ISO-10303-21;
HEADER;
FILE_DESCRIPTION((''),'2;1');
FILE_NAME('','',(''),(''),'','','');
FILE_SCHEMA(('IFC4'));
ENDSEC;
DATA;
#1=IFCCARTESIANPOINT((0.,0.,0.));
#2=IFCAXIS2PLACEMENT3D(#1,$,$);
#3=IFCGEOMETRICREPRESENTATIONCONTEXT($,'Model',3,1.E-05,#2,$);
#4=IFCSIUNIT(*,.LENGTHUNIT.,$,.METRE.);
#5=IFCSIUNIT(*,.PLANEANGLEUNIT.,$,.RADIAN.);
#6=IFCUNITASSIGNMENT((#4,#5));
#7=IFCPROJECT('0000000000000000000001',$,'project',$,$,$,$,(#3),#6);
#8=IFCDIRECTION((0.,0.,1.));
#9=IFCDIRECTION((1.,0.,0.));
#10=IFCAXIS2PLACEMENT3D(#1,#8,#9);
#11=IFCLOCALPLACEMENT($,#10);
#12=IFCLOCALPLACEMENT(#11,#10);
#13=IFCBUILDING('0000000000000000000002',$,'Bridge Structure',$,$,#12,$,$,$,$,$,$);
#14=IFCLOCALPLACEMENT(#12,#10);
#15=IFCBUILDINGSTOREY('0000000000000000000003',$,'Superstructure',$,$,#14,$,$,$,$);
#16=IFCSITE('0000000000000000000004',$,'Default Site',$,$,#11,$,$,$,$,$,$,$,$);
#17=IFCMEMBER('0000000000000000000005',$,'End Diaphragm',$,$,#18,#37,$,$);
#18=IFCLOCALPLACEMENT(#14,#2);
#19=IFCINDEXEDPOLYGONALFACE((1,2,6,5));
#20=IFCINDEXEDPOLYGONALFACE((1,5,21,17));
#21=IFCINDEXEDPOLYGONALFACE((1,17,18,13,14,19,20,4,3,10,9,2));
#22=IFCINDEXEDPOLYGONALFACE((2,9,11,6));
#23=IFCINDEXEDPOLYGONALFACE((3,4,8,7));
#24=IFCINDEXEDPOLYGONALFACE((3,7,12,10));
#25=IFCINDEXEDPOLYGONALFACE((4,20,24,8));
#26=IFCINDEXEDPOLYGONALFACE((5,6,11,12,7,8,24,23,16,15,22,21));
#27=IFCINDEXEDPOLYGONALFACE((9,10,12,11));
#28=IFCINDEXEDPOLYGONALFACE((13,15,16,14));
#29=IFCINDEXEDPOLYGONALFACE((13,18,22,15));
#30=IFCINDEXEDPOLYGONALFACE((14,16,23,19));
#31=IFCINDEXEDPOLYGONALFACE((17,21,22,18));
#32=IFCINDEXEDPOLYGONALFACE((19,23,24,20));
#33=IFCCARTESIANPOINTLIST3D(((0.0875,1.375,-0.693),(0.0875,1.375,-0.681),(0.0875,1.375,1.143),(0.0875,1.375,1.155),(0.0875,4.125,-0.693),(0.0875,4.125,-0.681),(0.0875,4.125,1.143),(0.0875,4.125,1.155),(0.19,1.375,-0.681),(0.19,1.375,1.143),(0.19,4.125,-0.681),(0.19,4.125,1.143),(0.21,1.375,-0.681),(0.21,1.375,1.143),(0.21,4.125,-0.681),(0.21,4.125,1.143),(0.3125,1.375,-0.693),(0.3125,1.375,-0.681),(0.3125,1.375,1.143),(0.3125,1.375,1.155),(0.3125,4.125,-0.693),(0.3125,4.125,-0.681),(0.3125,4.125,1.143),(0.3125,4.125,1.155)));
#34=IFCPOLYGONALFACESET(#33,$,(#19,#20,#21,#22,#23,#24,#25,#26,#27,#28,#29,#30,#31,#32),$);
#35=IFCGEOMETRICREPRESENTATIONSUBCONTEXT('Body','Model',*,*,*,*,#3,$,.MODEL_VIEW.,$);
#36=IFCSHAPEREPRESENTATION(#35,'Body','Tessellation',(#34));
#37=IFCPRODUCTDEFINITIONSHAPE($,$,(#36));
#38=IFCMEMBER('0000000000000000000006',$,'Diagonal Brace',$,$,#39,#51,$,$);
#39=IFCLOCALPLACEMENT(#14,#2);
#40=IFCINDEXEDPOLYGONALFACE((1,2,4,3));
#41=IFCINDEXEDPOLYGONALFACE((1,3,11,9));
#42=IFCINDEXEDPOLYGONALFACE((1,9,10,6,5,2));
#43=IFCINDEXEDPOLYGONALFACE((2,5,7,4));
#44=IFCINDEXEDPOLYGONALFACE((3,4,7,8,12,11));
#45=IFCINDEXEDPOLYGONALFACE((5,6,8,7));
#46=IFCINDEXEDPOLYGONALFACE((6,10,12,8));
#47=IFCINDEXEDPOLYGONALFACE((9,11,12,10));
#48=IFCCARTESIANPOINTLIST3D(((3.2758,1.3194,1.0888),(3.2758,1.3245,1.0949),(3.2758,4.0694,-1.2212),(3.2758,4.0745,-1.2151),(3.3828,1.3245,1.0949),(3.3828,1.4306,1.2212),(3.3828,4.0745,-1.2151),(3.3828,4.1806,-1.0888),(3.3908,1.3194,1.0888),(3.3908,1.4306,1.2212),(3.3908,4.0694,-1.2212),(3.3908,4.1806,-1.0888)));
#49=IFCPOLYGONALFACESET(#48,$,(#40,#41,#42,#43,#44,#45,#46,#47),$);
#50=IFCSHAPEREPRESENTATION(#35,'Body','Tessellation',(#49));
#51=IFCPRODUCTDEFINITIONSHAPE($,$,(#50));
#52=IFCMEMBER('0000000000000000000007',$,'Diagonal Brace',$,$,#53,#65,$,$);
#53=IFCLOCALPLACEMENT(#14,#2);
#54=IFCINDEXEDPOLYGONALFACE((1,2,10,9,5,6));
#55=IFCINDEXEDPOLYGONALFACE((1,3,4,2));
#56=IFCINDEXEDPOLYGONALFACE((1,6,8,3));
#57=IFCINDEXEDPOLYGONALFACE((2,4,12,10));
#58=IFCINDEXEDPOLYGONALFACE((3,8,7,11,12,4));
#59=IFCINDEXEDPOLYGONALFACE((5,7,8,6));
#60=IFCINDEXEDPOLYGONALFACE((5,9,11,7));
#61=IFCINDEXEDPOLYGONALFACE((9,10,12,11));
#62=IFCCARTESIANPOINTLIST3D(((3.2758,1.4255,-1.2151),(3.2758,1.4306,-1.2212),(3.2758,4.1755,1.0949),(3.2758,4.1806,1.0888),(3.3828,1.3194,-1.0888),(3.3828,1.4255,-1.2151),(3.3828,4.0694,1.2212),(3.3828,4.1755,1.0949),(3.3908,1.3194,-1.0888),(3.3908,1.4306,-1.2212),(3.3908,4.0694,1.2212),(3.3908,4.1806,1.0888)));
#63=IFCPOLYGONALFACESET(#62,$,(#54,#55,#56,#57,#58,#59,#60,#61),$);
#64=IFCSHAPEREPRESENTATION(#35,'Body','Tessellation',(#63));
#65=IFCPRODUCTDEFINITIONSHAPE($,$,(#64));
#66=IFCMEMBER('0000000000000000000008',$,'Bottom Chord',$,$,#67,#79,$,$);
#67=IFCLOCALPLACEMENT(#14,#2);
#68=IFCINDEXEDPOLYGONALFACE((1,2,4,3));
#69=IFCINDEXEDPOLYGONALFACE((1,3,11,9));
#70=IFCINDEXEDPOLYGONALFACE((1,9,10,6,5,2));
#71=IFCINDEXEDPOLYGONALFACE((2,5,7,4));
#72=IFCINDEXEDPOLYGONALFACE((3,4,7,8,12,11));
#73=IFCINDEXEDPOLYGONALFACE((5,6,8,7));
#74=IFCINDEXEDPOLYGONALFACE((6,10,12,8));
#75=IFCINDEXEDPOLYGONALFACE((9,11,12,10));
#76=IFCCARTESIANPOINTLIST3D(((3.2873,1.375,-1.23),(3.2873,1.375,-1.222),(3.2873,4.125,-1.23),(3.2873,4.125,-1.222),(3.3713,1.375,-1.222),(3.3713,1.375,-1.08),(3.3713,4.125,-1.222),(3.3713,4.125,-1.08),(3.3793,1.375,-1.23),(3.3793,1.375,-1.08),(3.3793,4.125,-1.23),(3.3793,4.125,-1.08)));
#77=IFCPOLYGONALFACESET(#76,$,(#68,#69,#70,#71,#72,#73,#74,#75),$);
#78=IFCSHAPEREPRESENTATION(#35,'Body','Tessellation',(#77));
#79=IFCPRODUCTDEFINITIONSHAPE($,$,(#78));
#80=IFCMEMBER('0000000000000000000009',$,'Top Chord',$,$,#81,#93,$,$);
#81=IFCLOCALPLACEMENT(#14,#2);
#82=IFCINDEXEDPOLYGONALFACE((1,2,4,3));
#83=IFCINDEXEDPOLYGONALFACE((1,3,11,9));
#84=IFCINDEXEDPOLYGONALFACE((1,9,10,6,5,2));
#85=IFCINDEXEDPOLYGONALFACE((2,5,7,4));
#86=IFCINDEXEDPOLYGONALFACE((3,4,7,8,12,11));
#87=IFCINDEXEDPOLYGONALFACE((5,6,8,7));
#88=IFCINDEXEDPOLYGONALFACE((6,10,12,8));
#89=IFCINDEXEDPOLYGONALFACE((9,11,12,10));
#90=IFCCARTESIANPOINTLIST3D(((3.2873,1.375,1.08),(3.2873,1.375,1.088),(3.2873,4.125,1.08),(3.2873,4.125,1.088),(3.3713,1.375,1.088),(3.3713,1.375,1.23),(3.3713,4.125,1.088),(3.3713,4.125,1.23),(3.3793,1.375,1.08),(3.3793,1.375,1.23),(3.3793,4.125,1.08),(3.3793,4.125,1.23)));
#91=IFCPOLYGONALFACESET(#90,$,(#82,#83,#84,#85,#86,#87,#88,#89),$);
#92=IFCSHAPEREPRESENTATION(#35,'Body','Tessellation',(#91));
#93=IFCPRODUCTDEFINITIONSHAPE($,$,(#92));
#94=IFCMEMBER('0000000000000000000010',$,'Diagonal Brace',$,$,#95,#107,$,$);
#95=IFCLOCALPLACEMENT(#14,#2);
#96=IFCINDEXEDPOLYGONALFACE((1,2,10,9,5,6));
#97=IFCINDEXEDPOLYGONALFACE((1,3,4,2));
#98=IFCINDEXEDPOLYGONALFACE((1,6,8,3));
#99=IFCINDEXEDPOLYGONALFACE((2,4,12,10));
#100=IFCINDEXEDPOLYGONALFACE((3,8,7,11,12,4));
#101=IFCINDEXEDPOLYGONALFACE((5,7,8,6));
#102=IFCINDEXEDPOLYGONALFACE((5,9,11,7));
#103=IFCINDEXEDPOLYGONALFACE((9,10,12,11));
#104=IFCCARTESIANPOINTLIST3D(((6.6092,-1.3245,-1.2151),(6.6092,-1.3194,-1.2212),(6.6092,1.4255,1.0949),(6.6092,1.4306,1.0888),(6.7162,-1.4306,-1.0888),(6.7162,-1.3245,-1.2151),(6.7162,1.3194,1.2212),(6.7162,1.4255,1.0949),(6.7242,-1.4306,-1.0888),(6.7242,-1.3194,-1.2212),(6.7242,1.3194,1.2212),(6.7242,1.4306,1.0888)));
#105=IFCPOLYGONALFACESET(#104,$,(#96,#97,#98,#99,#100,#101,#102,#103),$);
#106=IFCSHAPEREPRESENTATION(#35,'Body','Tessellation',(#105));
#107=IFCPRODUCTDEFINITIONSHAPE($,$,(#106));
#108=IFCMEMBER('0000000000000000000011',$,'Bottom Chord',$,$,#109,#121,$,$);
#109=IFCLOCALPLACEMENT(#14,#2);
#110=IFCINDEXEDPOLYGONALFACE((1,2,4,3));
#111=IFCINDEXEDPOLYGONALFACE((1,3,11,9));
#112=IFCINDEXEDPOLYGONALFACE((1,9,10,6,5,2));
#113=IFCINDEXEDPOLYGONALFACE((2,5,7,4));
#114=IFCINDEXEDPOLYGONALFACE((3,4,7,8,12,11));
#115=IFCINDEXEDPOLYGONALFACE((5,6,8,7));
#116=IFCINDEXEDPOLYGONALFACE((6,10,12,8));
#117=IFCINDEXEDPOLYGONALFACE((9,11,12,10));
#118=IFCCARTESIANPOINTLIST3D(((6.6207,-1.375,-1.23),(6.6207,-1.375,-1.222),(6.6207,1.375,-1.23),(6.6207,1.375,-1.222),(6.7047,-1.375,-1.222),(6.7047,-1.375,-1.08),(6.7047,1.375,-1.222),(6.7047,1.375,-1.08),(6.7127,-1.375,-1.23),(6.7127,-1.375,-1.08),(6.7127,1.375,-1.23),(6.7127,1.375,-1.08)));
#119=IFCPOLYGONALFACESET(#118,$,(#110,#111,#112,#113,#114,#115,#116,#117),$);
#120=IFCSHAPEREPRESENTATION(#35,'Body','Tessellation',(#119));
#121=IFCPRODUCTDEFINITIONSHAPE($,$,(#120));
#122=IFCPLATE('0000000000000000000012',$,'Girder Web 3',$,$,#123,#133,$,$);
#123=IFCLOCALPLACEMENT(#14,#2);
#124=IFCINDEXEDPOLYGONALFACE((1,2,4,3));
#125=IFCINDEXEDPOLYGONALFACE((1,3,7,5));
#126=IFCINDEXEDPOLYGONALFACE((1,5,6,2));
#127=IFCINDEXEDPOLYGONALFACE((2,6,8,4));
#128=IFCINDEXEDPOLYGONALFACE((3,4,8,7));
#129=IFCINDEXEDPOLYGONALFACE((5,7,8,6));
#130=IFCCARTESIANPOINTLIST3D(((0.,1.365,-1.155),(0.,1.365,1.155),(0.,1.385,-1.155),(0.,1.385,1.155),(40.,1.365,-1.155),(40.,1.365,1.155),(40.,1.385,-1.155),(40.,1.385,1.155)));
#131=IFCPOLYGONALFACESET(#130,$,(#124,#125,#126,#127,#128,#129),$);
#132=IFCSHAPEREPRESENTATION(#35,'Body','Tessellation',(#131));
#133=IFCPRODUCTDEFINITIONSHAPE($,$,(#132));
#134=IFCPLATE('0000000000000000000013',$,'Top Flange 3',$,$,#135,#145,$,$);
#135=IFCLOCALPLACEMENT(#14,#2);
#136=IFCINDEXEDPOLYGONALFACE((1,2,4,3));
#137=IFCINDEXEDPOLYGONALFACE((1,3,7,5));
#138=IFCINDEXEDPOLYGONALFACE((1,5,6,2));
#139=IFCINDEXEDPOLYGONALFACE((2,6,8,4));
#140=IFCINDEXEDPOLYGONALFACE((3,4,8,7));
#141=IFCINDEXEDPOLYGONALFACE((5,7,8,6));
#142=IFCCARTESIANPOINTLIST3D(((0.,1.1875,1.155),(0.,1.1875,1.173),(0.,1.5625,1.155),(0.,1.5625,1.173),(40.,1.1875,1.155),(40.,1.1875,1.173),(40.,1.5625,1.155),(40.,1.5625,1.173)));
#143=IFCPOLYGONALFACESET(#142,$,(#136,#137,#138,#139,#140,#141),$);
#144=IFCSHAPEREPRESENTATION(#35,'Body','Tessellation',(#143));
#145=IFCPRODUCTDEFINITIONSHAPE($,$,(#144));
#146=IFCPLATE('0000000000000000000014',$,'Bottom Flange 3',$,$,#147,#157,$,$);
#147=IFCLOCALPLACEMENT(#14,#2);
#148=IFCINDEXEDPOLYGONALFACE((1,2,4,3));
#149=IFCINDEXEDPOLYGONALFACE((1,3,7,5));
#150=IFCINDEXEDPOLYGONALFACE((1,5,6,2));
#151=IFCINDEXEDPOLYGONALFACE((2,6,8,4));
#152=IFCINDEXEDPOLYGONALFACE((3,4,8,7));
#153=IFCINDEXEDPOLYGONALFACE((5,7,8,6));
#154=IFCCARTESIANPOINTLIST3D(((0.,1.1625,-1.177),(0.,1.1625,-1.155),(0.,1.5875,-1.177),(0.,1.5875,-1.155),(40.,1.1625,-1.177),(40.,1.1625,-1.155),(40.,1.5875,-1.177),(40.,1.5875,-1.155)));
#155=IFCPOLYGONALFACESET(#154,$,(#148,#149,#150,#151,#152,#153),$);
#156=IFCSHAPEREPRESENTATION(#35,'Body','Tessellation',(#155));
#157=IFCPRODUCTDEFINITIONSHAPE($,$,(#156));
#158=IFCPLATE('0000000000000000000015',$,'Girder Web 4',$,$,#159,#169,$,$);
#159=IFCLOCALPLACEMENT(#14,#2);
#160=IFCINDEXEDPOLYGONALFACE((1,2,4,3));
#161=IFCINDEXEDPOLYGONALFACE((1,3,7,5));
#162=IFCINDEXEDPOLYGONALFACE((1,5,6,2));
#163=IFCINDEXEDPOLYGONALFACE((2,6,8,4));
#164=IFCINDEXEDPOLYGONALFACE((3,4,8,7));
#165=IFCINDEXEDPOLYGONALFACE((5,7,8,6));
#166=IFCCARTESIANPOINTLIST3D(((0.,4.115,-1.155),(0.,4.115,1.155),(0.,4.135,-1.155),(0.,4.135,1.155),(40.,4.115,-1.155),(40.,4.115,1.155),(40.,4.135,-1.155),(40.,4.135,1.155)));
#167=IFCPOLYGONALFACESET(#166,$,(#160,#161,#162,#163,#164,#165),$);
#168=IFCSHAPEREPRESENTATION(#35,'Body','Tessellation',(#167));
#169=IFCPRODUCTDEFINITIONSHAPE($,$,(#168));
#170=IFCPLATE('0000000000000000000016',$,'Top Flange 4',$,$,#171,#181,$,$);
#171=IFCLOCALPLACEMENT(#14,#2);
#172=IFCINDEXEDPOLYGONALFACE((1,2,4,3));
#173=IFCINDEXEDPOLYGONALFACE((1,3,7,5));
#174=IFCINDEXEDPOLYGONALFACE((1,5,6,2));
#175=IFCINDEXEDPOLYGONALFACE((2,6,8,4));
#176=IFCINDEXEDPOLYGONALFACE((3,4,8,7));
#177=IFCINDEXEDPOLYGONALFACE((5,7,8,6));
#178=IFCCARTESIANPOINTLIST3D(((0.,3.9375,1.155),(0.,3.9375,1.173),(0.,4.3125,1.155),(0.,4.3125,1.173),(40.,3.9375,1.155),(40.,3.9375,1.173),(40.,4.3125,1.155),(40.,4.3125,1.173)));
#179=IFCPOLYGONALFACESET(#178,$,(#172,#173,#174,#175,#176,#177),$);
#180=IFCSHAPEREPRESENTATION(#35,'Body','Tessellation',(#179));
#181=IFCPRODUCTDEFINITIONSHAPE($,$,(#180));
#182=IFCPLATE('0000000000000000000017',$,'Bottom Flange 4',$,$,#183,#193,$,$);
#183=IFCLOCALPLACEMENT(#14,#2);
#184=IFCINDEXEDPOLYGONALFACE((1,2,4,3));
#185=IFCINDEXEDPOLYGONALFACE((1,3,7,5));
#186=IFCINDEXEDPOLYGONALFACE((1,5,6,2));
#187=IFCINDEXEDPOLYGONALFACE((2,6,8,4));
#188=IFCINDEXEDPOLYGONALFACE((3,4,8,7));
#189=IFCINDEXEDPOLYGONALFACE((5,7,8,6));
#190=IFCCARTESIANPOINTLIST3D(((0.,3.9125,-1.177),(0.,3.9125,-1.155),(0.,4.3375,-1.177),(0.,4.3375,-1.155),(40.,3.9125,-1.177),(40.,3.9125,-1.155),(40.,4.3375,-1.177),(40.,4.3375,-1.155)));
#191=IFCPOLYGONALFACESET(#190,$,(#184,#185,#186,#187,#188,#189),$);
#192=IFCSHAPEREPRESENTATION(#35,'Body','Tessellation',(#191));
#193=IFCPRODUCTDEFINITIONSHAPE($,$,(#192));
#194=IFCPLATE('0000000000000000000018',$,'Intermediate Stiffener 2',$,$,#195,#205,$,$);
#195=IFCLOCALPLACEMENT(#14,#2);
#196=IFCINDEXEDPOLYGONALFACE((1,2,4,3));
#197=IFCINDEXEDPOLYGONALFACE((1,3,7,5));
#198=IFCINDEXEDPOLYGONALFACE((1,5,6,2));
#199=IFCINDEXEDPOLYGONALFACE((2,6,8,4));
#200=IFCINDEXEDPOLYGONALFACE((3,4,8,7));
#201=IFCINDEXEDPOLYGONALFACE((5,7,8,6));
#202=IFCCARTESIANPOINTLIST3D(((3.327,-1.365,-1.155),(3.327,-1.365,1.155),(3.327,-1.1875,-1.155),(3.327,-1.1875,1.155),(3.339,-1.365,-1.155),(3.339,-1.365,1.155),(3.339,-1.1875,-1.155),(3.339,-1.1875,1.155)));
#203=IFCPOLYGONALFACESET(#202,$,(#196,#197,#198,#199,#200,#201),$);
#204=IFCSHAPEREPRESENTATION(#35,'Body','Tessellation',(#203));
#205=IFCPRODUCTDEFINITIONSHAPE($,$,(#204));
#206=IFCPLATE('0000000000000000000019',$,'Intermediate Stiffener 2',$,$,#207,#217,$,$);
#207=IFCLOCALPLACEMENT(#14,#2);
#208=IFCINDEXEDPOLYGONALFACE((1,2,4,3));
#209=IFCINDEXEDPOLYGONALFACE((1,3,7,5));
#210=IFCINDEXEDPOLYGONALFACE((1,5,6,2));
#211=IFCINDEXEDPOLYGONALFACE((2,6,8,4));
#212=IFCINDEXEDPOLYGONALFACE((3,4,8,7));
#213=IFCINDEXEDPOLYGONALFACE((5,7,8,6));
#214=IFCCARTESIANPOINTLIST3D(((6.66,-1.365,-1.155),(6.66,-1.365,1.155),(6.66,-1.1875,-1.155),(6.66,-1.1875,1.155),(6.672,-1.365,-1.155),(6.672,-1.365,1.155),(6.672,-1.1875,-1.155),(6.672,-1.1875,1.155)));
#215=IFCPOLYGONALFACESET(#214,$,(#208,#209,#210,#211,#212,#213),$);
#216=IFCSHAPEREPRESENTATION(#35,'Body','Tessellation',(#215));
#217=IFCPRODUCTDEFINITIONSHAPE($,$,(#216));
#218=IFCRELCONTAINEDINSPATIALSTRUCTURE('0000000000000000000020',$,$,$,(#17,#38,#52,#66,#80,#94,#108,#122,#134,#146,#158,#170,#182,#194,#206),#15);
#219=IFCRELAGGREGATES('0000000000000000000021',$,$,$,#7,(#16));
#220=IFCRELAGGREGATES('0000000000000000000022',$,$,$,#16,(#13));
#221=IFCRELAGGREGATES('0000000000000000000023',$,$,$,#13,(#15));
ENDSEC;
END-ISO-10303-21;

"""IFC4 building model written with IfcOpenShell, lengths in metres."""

from ifc_helpers import new_model, si_unit, frame, origin, origin_with_axes, origin_2d_with_axis, place, context, subcontext, project, spatial, rectangle, i_section, l_section, extrude, element, save


model = new_model("IFC4")

# Units and contexts
model_context = context("Model", 3, precision=1e-05, world=origin())
body_context = subcontext(model_context, "Body", "Model", "MODEL_VIEW")
ifc_project = project(units=[si_unit("LENGTHUNIT", "METRE"), si_unit("PLANEANGLEUNIT", "RADIAN")], contexts=[model_context])

# Site, building, storey
site_placement = place(None, origin_with_axes())
site = spatial("IfcSite", under=ifc_project, at=site_placement, Name="Default Site")
building_placement = place(site_placement, origin_with_axes())
building = spatial("IfcBuilding", under=site, at=building_placement, Name="Bridge Structure")
storey_placement = place(building_placement, origin_with_axes())
storey = spatial("IfcBuildingStorey", under=building, at=storey_placement, Name="Superstructure")

# Members
member_1_placement = place(storey_placement, frame((0.2, 1.375, 0.231), z_axis=(0.0, 1.0, 0.0), x_axis=(-1.0, 0.0, 0.0)))
element("IfcMember", 1, at=member_1_placement, inside=storey, Name="End Diaphragm", context=body_context, shape_type="SweptSolid", body=[
    extrude(i_section(OverallWidth=0.225, OverallDepth=1.848, WebThickness=0.02, FlangeThickness=0.012, at=origin_2d_with_axis()), origin_with_axes(), (0.0, 0.0, 1.0), 2.75),
])
for number, where, z_axis, x_axis, name in (
    (2, (3.3333, 1.375, 1.155), (0.0, 0.765705, -0.643192), (-1.0, 0.0, 0.0), "Diagonal Brace"),
    (3, (3.3333, 1.375, -1.155), (0.0, 0.765705, 0.643192), (-1.0, 0.0, 0.0), "Diagonal Brace"),
):
    element("IfcMember", number, at=place(storey_placement, frame(where, z_axis=z_axis, x_axis=x_axis)), inside=storey, Name=name, context=body_context, shape_type="SweptSolid", body=[
        extrude(l_section(Depth=0.173, Width=0.115, Thickness=0.008, at=origin_2d_with_axis()), origin_with_axes(), (0.0, 0.0, 1.0), 3.5915),
    ])
for number, where, z_axis, x_axis, name in (
    (4, (3.3333, 1.375, -1.155), (0.0, 1.0, 0.0), (-1.0, 0.0, 0.0), "Bottom Chord"),
    (5, (3.3333, 1.375, 1.155), (0.0, 1.0, 0.0), (-1.0, 0.0, 0.0), "Top Chord"),
):
    element("IfcMember", number, at=place(storey_placement, frame(where, z_axis=z_axis, x_axis=x_axis)), inside=storey, Name=name, context=body_context, shape_type="SweptSolid", body=[
        extrude(l_section(Depth=0.15, Width=0.092, Thickness=0.008, at=origin_2d_with_axis()), origin_with_axes(), (0.0, 0.0, 1.0), 2.75),
    ])
member_2_placement = place(storey_placement, frame((6.6667, -1.375, -1.155), z_axis=(0.0, 0.765705, 0.643192), x_axis=(-1.0, 0.0, 0.0)))
element("IfcMember", 6, at=member_2_placement, inside=storey, Name="Diagonal Brace", context=body_context, shape_type="SweptSolid", body=[
    extrude(l_section(Depth=0.173, Width=0.115, Thickness=0.008, at=origin_2d_with_axis()), origin_with_axes(), (0.0, 0.0, 1.0), 3.5915),
])
member_3_placement = place(storey_placement, frame((6.6667, -1.375, -1.155), z_axis=(0.0, 1.0, 0.0), x_axis=(-1.0, 0.0, 0.0)))
element("IfcMember", 7, at=member_3_placement, inside=storey, Name="Bottom Chord", context=body_context, shape_type="SweptSolid", body=[
    extrude(l_section(Depth=0.15, Width=0.092, Thickness=0.008, at=origin_2d_with_axis()), origin_with_axes(), (0.0, 0.0, 1.0), 2.75),
])

# Plates
plate_1_placement = place(storey_placement, frame((0.0, 1.375, 0.0), z_axis=(1.0, 0.0, 0.0), x_axis=(0.0, 1.0, 0.0)))
element("IfcPlate", 8, at=plate_1_placement, inside=storey, Name="Girder Web 3", context=body_context, shape_type="SweptSolid", body=[
    extrude(rectangle(XDim=0.02, YDim=2.31, at=origin_2d_with_axis()), origin_with_axes(), (0.0, 0.0, 1.0), 40.0),
])
plate_2_placement = place(storey_placement, frame((0.0, 1.375, 1.164), z_axis=(1.0, 0.0, 0.0), x_axis=(0.0, 1.0, 0.0)))
element("IfcPlate", 9, at=plate_2_placement, inside=storey, Name="Top Flange 3", context=body_context, shape_type="SweptSolid", body=[
    extrude(rectangle(XDim=0.375, YDim=0.018, at=origin_2d_with_axis()), origin_with_axes(), (0.0, 0.0, 1.0), 40.0),
])
plate_3_placement = place(storey_placement, frame((0.0, 1.375, -1.166), z_axis=(1.0, 0.0, 0.0), x_axis=(0.0, 1.0, 0.0)))
element("IfcPlate", 10, at=plate_3_placement, inside=storey, Name="Bottom Flange 3", context=body_context, shape_type="SweptSolid", body=[
    extrude(rectangle(XDim=0.425, YDim=0.022, at=origin_2d_with_axis()), origin_with_axes(), (0.0, 0.0, 1.0), 40.0),
])
plate_4_placement = place(storey_placement, frame((0.0, 4.125, 0.0), z_axis=(1.0, 0.0, 0.0), x_axis=(0.0, 1.0, 0.0)))
element("IfcPlate", 11, at=plate_4_placement, inside=storey, Name="Girder Web 4", context=body_context, shape_type="SweptSolid", body=[
    extrude(rectangle(XDim=0.02, YDim=2.31, at=origin_2d_with_axis()), origin_with_axes(), (0.0, 0.0, 1.0), 40.0),
])
plate_5_placement = place(storey_placement, frame((0.0, 4.125, 1.164), z_axis=(1.0, 0.0, 0.0), x_axis=(0.0, 1.0, 0.0)))
element("IfcPlate", 12, at=plate_5_placement, inside=storey, Name="Top Flange 4", context=body_context, shape_type="SweptSolid", body=[
    extrude(rectangle(XDim=0.375, YDim=0.018, at=origin_2d_with_axis()), origin_with_axes(), (0.0, 0.0, 1.0), 40.0),
])
plate_6_placement = place(storey_placement, frame((0.0, 4.125, -1.166), z_axis=(1.0, 0.0, 0.0), x_axis=(0.0, 1.0, 0.0)))
element("IfcPlate", 13, at=plate_6_placement, inside=storey, Name="Bottom Flange 4", context=body_context, shape_type="SweptSolid", body=[
    extrude(rectangle(XDim=0.425, YDim=0.022, at=origin_2d_with_axis()), origin_with_axes(), (0.0, 0.0, 1.0), 40.0),
])
for number, where, z_axis, x_axis, name in (
    (14, (3.333, -1.2763, -1.155), (0.0, 0.0, 1.0), (1.0, 0.0, 0.0), "Intermediate Stiffener 2"),
    (15, (6.666, -1.2763, -1.155), (0.0, 0.0, 1.0), (1.0, 0.0, 0.0), "Intermediate Stiffener 2"),
):
    element("IfcPlate", number, at=place(storey_placement, frame(where, z_axis=z_axis, x_axis=x_axis)), inside=storey, Name=name, context=body_context, shape_type="SweptSolid", body=[
        extrude(rectangle(XDim=0.012, YDim=0.1775, at=origin_2d_with_axis()), origin_with_axes(), (0.0, 0.0, 1.0), 2.31),
    ])

save(model, "model.ifc")
